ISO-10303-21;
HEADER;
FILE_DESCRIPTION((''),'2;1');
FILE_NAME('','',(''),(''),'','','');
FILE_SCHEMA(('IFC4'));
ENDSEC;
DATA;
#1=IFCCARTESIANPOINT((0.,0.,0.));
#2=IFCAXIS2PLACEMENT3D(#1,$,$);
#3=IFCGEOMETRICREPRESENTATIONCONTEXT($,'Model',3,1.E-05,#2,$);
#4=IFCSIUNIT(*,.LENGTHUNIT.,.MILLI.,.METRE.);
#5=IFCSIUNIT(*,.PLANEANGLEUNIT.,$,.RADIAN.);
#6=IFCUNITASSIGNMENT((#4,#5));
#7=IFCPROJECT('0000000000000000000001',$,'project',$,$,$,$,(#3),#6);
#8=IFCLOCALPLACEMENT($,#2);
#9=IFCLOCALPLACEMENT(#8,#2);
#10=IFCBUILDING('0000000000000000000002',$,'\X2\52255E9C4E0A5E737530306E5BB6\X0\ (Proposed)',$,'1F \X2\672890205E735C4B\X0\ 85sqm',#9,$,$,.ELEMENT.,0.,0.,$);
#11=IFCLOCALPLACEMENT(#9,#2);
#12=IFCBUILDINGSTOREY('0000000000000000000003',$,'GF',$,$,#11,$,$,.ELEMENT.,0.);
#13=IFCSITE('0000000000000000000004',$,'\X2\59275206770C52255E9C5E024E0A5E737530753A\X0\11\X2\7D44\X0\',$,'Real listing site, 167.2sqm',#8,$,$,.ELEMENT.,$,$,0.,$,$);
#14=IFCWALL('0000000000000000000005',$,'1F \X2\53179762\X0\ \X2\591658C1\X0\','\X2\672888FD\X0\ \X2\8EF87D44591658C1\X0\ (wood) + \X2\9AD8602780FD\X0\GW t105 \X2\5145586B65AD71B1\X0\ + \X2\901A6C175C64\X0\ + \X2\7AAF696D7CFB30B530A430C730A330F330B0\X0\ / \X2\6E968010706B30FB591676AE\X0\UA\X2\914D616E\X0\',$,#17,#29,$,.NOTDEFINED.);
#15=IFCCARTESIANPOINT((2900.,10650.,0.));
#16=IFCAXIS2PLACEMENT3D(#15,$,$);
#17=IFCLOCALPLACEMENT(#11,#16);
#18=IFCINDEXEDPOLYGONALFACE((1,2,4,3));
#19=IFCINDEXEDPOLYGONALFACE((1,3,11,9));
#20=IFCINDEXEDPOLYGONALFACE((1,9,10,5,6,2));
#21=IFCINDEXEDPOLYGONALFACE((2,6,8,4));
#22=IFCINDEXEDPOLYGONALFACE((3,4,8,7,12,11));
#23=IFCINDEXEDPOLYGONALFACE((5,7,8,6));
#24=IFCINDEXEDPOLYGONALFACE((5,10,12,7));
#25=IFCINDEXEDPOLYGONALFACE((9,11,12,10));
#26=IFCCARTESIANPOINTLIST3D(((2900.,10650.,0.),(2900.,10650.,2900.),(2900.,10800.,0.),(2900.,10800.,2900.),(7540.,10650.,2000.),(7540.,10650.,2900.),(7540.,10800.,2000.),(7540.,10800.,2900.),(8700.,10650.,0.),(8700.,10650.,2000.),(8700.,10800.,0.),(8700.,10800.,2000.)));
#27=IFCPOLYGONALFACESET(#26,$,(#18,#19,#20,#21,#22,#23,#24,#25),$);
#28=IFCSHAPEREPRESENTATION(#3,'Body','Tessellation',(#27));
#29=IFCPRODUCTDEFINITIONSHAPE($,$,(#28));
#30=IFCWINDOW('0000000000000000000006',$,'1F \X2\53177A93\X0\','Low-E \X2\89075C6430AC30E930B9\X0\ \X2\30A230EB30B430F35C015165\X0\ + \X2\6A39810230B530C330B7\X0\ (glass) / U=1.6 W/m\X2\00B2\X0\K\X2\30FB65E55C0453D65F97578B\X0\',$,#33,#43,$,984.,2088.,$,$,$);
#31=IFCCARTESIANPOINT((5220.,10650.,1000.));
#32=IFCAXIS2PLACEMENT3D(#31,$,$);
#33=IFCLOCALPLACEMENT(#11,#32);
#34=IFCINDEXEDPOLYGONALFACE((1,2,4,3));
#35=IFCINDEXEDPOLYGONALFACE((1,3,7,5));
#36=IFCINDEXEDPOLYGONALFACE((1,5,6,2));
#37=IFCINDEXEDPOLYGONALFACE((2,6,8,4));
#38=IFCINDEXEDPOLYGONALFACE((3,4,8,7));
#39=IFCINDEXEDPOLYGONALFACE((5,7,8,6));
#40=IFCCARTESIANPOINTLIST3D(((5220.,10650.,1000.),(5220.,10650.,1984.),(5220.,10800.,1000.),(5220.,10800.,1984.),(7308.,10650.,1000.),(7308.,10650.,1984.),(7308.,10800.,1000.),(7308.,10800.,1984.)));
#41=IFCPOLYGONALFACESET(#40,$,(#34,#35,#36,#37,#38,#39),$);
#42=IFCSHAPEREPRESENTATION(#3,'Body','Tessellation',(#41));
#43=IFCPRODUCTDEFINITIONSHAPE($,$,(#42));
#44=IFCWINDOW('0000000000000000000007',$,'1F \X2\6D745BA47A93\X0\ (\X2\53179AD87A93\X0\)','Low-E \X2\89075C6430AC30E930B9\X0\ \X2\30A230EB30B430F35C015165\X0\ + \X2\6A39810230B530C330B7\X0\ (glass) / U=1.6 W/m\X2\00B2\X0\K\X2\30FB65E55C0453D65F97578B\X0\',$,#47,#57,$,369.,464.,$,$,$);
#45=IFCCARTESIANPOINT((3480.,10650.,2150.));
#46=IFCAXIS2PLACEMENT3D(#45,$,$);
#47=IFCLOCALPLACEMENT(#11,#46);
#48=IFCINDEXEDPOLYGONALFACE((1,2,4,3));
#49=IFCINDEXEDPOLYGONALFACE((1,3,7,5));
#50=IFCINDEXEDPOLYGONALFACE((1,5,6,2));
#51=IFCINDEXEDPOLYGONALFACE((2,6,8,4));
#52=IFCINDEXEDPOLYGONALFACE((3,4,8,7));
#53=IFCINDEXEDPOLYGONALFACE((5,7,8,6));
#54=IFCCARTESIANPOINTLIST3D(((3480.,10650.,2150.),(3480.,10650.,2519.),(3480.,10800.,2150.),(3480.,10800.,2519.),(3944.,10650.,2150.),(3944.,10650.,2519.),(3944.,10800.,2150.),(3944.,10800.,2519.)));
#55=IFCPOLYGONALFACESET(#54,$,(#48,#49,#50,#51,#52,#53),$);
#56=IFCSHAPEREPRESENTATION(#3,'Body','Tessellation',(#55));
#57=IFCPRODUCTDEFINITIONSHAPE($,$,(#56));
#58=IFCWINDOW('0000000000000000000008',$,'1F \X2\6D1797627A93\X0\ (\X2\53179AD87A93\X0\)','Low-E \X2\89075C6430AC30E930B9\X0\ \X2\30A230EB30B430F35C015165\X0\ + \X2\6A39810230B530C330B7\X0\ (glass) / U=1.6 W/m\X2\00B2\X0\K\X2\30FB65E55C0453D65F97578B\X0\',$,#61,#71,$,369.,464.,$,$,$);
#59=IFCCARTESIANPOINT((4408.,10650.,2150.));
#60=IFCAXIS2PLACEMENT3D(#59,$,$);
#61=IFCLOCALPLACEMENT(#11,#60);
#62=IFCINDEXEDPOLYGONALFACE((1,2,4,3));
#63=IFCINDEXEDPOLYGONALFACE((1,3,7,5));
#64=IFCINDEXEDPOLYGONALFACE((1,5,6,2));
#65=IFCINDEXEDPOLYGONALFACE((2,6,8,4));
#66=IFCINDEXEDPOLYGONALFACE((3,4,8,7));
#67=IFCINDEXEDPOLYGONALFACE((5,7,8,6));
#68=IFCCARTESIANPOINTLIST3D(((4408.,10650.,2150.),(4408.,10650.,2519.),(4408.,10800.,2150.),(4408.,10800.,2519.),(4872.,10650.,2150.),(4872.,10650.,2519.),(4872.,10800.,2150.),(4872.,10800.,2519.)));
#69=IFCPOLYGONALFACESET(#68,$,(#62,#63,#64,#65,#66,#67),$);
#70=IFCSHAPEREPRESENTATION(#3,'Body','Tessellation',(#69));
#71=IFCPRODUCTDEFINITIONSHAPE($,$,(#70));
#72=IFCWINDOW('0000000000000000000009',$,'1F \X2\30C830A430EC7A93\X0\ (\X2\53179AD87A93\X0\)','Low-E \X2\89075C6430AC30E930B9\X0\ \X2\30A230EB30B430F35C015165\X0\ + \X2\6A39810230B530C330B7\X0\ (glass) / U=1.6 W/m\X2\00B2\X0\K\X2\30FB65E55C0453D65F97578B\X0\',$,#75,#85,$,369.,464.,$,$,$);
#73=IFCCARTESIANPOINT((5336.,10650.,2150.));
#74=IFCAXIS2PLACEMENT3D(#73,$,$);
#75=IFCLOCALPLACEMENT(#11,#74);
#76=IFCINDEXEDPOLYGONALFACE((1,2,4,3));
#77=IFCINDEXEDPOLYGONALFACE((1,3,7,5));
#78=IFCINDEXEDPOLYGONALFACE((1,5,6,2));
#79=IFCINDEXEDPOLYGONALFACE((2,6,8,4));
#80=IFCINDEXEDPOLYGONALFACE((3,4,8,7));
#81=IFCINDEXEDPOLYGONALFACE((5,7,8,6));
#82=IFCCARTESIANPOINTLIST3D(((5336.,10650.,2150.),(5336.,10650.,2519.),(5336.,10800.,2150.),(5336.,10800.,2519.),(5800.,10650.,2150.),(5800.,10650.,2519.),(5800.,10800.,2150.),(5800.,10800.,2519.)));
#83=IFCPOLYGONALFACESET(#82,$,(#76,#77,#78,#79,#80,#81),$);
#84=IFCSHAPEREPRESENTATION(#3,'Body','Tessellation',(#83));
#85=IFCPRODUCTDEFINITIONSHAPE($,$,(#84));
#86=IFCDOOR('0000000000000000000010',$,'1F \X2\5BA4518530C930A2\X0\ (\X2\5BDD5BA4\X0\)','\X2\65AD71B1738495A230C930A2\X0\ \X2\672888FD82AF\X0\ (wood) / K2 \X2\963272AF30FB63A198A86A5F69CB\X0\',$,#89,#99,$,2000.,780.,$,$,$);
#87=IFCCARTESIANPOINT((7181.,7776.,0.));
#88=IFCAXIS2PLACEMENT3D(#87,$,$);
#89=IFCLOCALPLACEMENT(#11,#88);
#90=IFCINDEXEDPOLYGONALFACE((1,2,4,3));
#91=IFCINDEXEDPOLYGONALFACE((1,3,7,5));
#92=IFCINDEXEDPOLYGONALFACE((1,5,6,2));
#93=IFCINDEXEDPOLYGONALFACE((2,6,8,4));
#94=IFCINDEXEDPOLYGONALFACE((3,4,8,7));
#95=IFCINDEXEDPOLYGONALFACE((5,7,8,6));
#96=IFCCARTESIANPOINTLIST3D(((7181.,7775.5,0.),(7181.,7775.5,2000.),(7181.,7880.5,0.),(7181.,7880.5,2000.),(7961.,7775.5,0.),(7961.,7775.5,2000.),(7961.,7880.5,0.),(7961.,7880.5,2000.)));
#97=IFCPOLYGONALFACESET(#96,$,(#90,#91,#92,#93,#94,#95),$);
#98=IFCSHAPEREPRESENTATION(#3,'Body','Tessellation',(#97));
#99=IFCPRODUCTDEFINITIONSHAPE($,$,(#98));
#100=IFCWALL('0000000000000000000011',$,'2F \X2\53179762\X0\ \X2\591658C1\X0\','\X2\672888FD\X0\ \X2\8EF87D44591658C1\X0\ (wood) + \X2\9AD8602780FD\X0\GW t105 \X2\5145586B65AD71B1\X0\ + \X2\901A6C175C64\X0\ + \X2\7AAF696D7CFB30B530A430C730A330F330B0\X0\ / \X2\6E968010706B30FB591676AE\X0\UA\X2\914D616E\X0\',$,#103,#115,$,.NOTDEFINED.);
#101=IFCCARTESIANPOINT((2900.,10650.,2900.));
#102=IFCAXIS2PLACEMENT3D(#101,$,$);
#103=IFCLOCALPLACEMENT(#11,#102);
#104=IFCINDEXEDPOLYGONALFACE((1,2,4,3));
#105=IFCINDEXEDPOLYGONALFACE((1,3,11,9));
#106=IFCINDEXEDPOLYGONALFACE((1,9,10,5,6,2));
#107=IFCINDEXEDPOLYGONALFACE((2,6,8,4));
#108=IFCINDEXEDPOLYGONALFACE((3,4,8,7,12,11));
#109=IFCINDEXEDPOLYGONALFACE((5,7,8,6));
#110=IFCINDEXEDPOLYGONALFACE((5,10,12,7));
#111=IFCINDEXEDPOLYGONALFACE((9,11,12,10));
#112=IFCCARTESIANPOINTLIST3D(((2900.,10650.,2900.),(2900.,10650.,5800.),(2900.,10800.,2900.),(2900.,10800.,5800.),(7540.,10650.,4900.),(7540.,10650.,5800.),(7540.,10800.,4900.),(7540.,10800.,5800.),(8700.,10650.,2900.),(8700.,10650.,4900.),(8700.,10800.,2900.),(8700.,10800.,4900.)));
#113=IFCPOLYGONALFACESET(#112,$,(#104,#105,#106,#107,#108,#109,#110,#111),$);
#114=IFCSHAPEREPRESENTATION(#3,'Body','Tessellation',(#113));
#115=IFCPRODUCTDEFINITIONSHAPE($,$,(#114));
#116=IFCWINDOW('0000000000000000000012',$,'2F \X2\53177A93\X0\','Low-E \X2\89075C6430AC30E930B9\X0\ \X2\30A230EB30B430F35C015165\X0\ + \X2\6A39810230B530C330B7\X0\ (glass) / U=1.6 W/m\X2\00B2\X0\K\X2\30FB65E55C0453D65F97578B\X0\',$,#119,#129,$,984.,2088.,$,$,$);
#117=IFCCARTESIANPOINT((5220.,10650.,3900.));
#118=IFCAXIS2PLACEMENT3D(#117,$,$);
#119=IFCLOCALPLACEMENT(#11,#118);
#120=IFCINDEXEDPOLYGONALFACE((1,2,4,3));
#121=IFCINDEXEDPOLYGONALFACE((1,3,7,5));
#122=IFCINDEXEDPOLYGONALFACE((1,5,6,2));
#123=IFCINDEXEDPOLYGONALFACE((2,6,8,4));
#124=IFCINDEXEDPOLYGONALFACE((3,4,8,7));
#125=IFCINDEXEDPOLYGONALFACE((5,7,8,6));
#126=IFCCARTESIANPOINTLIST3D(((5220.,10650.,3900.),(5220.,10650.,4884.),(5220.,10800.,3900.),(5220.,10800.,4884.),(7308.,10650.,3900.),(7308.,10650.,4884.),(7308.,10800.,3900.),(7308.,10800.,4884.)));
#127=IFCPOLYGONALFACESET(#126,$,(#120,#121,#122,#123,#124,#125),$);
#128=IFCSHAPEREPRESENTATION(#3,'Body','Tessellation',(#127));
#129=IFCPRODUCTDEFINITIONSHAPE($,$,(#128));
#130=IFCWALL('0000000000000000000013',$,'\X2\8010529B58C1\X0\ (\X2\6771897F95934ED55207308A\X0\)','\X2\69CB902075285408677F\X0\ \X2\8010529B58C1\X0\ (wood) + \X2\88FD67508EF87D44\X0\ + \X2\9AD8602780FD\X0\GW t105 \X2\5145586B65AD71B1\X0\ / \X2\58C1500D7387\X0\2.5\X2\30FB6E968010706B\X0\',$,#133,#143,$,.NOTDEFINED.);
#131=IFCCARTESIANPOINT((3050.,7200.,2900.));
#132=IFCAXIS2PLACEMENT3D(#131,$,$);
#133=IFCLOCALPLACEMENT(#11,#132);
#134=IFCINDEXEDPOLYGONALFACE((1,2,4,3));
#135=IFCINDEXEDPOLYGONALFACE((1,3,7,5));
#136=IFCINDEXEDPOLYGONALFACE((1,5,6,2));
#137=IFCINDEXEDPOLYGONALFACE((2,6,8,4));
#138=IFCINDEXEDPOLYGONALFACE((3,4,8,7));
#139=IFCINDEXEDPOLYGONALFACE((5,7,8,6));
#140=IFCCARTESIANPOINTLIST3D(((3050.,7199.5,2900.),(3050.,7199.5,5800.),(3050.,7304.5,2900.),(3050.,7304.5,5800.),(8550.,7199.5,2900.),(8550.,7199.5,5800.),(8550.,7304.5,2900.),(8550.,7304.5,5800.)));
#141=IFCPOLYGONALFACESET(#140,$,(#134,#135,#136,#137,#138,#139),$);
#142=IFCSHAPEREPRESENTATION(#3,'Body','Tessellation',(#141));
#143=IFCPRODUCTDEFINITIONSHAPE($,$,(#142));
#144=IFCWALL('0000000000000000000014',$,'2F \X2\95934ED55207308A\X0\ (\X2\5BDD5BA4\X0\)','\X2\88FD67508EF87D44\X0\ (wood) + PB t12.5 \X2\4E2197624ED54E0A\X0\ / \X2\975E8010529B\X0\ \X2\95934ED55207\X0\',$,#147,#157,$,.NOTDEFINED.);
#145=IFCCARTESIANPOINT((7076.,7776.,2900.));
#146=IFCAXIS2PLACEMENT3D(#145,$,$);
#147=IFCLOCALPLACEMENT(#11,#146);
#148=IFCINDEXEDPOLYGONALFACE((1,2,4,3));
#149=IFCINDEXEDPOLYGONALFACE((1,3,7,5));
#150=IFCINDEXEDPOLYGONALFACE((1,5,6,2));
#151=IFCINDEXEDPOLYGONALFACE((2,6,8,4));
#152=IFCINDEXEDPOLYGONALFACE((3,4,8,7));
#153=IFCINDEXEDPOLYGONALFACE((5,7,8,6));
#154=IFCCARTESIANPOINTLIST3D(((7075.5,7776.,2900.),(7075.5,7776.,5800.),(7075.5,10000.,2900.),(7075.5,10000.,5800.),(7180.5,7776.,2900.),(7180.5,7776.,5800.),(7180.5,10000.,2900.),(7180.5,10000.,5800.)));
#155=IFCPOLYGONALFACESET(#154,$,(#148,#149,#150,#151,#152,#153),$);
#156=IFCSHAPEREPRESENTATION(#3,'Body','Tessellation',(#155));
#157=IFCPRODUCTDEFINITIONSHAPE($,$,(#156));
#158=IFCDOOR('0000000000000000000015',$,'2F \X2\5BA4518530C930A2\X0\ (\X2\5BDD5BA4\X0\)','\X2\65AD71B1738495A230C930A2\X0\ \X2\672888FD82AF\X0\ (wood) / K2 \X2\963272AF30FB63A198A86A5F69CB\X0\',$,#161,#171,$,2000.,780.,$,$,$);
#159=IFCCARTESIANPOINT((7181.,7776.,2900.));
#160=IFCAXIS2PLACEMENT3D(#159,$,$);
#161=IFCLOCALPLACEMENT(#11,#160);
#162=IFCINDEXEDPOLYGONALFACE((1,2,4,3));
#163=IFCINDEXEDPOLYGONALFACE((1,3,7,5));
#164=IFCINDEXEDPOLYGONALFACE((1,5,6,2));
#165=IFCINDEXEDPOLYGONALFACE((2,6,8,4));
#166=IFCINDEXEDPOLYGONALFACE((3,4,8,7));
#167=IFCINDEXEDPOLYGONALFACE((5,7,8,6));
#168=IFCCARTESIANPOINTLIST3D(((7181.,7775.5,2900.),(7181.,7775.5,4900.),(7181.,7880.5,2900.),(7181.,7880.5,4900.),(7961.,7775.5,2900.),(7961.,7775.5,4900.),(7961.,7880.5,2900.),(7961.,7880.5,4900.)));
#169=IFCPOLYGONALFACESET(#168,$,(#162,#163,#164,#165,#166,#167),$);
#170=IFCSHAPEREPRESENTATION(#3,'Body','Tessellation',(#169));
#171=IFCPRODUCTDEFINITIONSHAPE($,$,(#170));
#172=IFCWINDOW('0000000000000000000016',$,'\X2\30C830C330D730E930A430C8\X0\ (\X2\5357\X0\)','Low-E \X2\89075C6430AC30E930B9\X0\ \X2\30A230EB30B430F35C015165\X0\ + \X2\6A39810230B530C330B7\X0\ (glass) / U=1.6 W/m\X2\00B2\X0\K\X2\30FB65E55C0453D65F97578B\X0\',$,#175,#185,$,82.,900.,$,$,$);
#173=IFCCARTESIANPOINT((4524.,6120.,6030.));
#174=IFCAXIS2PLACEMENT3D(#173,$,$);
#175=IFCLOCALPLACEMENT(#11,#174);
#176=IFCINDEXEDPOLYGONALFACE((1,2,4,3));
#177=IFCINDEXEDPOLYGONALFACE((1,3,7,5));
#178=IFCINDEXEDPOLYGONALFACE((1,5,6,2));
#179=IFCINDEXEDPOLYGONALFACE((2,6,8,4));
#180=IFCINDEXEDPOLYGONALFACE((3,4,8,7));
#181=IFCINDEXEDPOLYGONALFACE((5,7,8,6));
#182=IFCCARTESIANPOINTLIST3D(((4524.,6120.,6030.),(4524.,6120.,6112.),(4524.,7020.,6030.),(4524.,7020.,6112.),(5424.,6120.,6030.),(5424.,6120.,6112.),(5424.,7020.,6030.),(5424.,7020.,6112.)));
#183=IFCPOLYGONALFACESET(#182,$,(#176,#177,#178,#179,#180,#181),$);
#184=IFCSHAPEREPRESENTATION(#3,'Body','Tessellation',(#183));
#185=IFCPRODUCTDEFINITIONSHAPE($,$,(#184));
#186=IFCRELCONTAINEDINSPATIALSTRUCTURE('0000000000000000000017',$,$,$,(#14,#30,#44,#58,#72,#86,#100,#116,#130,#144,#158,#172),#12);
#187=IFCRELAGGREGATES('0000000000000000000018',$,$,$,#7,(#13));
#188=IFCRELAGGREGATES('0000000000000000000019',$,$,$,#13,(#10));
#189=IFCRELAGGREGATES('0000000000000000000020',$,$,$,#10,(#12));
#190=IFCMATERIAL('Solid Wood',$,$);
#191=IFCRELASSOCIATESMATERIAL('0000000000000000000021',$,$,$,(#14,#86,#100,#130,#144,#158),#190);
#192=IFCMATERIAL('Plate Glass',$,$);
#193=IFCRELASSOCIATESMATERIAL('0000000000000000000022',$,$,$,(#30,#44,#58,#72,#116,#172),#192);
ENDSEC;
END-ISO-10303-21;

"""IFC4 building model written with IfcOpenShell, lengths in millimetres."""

from ifc_helpers import new_model, si_unit, frame, frame_2d, origin, place, context, project, spatial, rectangle, extrude, material, element, fill, save


model = new_model("IFC4")

# Units and contexts
model_context = context("Model", 3, precision=1e-05, world=origin())
ifc_project = project(units=[si_unit("LENGTHUNIT", "METRE", prefix="MILLI"), si_unit("PLANEANGLEUNIT", "RADIAN")], contexts=[model_context])

# Site, building, storey
site_placement = place(None, origin())
site = spatial("IfcSite", under=ifc_project, at=site_placement, Name="大分県別府市上平田町11組", ObjectType="Real listing site, 167.2sqm", CompositionType="ELEMENT", RefElevation=0.0)
building_placement = place(site_placement, origin())
building = spatial("IfcBuilding", under=site, at=building_placement, Name="別府上平田の家 (Proposed)", ObjectType="1F 木造平屋 85sqm", CompositionType="ELEMENT", ElevationOfRefHeight=0.0, ElevationOfTerrain=0.0)
storey_placement = place(building_placement, origin())
storey = spatial("IfcBuildingStorey", under=building, at=storey_placement, Name="GF", CompositionType="ELEMENT", Elevation=0.0)

# Wall, openings, windows
ifc_material_1 = material(Name="Solid Wood")
wall_1_placement = place(storey_placement, frame((2900.0, 10650.0, 0.0)))
wall_1 = element("IfcWall", 1, at=wall_1_placement, inside=storey, material=ifc_material_1, Name="1F 北面 外壁", Description="木製 軸組外壁 (wood) + 高性能GW t105 充填断熱 + 通気層 + 窯業系サイディング / 準耐火・外皮UA配慮", PredefinedType="NOTDEFINED", context=model_context, shape_type="SweptSolid", body=[
    extrude(rectangle(XDim=5800.0, YDim=150.0, at=frame_2d((2900.0, 75.0))), frame((2900.0, 10650.0, 0.0)), (0.0, 0.0, 1.0), 2900.0),
])
opening_1_placement = place(storey_placement, frame((5220.0, 10650.0, 1000.0)))
opening_1 = element("IfcOpeningElement", 2, at=opening_1_placement, cuts=wall_1, PredefinedType="NOTDEFINED", context=model_context, shape_type="SweptSolid", body=[
    extrude(rectangle(XDim=2088.0, YDim=150.0, at=frame_2d((1044.0, 75.0))), frame((5220.0, 10650.0, 1000.0)), (0.0, 0.0, 1.0), 984.0),
])
opening_2_placement = place(storey_placement, frame((3480.0, 10650.0, 2150.0)))
opening_2 = element("IfcOpeningElement", 3, at=opening_2_placement, cuts=wall_1, PredefinedType="NOTDEFINED", context=model_context, shape_type="SweptSolid", body=[
    extrude(rectangle(XDim=464.0, YDim=150.0, at=frame_2d((232.0, 75.0))), frame((3480.0, 10650.0, 2150.0)), (0.0, 0.0, 1.0), 369.0),
])
opening_3_placement = place(storey_placement, frame((4408.0, 10650.0, 2150.0)))
opening_3 = element("IfcOpeningElement", 4, at=opening_3_placement, cuts=wall_1, PredefinedType="NOTDEFINED", context=model_context, shape_type="SweptSolid", body=[
    extrude(rectangle(XDim=464.0, YDim=150.0, at=frame_2d((232.0, 75.0))), frame((4408.0, 10650.0, 2150.0)), (0.0, 0.0, 1.0), 369.0),
])
opening_4_placement = place(storey_placement, frame((5336.0, 10650.0, 2150.0)))
opening_4 = element("IfcOpeningElement", 5, at=opening_4_placement, cuts=wall_1, PredefinedType="NOTDEFINED", context=model_context, shape_type="SweptSolid", body=[
    extrude(rectangle(XDim=464.0, YDim=150.0, at=frame_2d((232.0, 75.0))), frame((5336.0, 10650.0, 2150.0)), (0.0, 0.0, 1.0), 369.0),
])
ifc_material_2 = material(Name="Plate Glass")
window_1_placement = place(storey_placement, frame((5220.0, 10650.0, 1000.0)))
window_1 = element("IfcWindow", 6, at=window_1_placement, inside=storey, material=ifc_material_2, Name="1F 北窓", Description="Low-E 複層ガラス アルゴン封入 + 樹脂サッシ (glass) / U=1.6 W/m²K・日射取得型", OverallHeight=984.0, OverallWidth=2088.0, context=model_context, shape_type="SweptSolid", body=[
    extrude(rectangle(XDim=2088.0, YDim=150.0, at=frame_2d((1044.0, 75.0))), frame((5220.0, 10650.0, 1000.0)), (0.0, 0.0, 1.0), 984.0),
])
fill(opening_1, window_1)
window_2_placement = place(storey_placement, frame((3480.0, 10650.0, 2150.0)))
window_2 = element("IfcWindow", 7, at=window_2_placement, inside=storey, material=ifc_material_2, Name="1F 浴室窓 (北高窓)", Description="Low-E 複層ガラス アルゴン封入 + 樹脂サッシ (glass) / U=1.6 W/m²K・日射取得型", OverallHeight=369.0, OverallWidth=464.0, context=model_context, shape_type="SweptSolid", body=[
    extrude(rectangle(XDim=464.0, YDim=150.0, at=frame_2d((232.0, 75.0))), frame((3480.0, 10650.0, 2150.0)), (0.0, 0.0, 1.0), 369.0),
])
fill(opening_2, window_2)
window_3_placement = place(storey_placement, frame((4408.0, 10650.0, 2150.0)))
window_3 = element("IfcWindow", 8, at=window_3_placement, inside=storey, material=ifc_material_2, Name="1F 洗面窓 (北高窓)", Description="Low-E 複層ガラス アルゴン封入 + 樹脂サッシ (glass) / U=1.6 W/m²K・日射取得型", OverallHeight=369.0, OverallWidth=464.0, context=model_context, shape_type="SweptSolid", body=[
    extrude(rectangle(XDim=464.0, YDim=150.0, at=frame_2d((232.0, 75.0))), frame((4408.0, 10650.0, 2150.0)), (0.0, 0.0, 1.0), 369.0),
])
fill(opening_3, window_3)
window_4_placement = place(storey_placement, frame((5336.0, 10650.0, 2150.0)))
window_4 = element("IfcWindow", 9, at=window_4_placement, inside=storey, material=ifc_material_2, Name="1F トイレ窓 (北高窓)", Description="Low-E 複層ガラス アルゴン封入 + 樹脂サッシ (glass) / U=1.6 W/m²K・日射取得型", OverallHeight=369.0, OverallWidth=464.0, context=model_context, shape_type="SweptSolid", body=[
    extrude(rectangle(XDim=464.0, YDim=150.0, at=frame_2d((232.0, 75.0))), frame((5336.0, 10650.0, 2150.0)), (0.0, 0.0, 1.0), 369.0),
])
fill(opening_4, window_4)

# Door
door_1_placement = place(storey_placement, frame((7181.0, 7776.0, 0.0)))
element("IfcDoor", 10, at=door_1_placement, inside=storey, material=ifc_material_1, Name="1F 室内ドア (寝室)", Description="断熱玄関ドア 木製芯 (wood) / K2 防犯・採風機構", OverallHeight=2000.0, OverallWidth=780.0, context=model_context, shape_type="SweptSolid", body=[
    extrude(rectangle(XDim=780.0, YDim=105.0, at=frame_2d((390.0, 52.0))), frame((7181.0, 7776.0, 0.0)), (0.0, 0.0, 1.0), 2000.0),
])

# Wall, opening, window
wall_2_placement = place(storey_placement, frame((2900.0, 10650.0, 2900.0)))
wall_2 = element("IfcWall", 11, at=wall_2_placement, inside=storey, material=ifc_material_1, Name="2F 北面 外壁", Description="木製 軸組外壁 (wood) + 高性能GW t105 充填断熱 + 通気層 + 窯業系サイディング / 準耐火・外皮UA配慮", PredefinedType="NOTDEFINED", context=model_context, shape_type="SweptSolid", body=[
    extrude(rectangle(XDim=5800.0, YDim=150.0, at=frame_2d((2900.0, 75.0))), frame((2900.0, 10650.0, 2900.0)), (0.0, 0.0, 1.0), 2900.0),
])
opening_5_placement = place(storey_placement, frame((5220.0, 10650.0, 3900.0)))
opening_5 = element("IfcOpeningElement", 12, at=opening_5_placement, cuts=wall_2, PredefinedType="NOTDEFINED", context=model_context, shape_type="SweptSolid", body=[
    extrude(rectangle(XDim=2088.0, YDim=150.0, at=frame_2d((1044.0, 75.0))), frame((5220.0, 10650.0, 3900.0)), (0.0, 0.0, 1.0), 984.0),
])
window_5_placement = place(storey_placement, frame((5220.0, 10650.0, 3900.0)))
window_5 = element("IfcWindow", 13, at=window_5_placement, inside=storey, material=ifc_material_2, Name="2F 北窓", Description="Low-E 複層ガラス アルゴン封入 + 樹脂サッシ (glass) / U=1.6 W/m²K・日射取得型", OverallHeight=984.0, OverallWidth=2088.0, context=model_context, shape_type="SweptSolid", body=[
    extrude(rectangle(XDim=2088.0, YDim=150.0, at=frame_2d((1044.0, 75.0))), frame((5220.0, 10650.0, 3900.0)), (0.0, 0.0, 1.0), 984.0),
])
fill(opening_5, window_5)

# Walls
wall_3_placement = place(storey_placement, frame((3050.0, 7200.0, 2900.0)))
element("IfcWall", 14, at=wall_3_placement, inside=storey, material=ifc_material_1, Name="耐力壁 (東西間仕切り)", Description="構造用合板 耐力壁 (wood) + 製材軸組 + 高性能GW t105 充填断熱 / 壁倍率2.5・準耐火", PredefinedType="NOTDEFINED", context=model_context, shape_type="SweptSolid", body=[
    extrude(rectangle(XDim=5500.0, YDim=105.0, at=frame_2d((2750.0, 52.0))), frame((3050.0, 7200.0, 2900.0)), (0.0, 0.0, 1.0), 2900.0),
])
wall_4_placement = place(storey_placement, frame((7076.0, 7776.0, 2900.0)))
element("IfcWall", 15, at=wall_4_placement, inside=storey, material=ifc_material_1, Name="2F 間仕切り (寝室)", Description="製材軸組 (wood) + PB t12.5 両面仕上 / 非耐力 間仕切", PredefinedType="NOTDEFINED", context=model_context, shape_type="SweptSolid", body=[
    extrude(rectangle(XDim=105.0, YDim=2224.0, at=frame_2d((52.0, 1112.0))), frame((7076.0, 7776.0, 2900.0)), (0.0, 0.0, 1.0), 2900.0),
])

# Door
door_2_placement = place(storey_placement, frame((7181.0, 7776.0, 2900.0)))
element("IfcDoor", 16, at=door_2_placement, inside=storey, material=ifc_material_1, Name="2F 室内ドア (寝室)", Description="断熱玄関ドア 木製芯 (wood) / K2 防犯・採風機構", OverallHeight=2000.0, OverallWidth=780.0, context=model_context, shape_type="SweptSolid", body=[
    extrude(rectangle(XDim=780.0, YDim=105.0, at=frame_2d((390.0, 52.0))), frame((7181.0, 7776.0, 2900.0)), (0.0, 0.0, 1.0), 2000.0),
])

# Window
window_6_placement = place(storey_placement, frame((4524.0, 6120.0, 6030.0)))
element("IfcWindow", 17, at=window_6_placement, inside=storey, material=ifc_material_2, Name="トップライト (南)", Description="Low-E 複層ガラス アルゴン封入 + 樹脂サッシ (glass) / U=1.6 W/m²K・日射取得型", OverallHeight=82.0, OverallWidth=900.0, context=model_context, shape_type="SweptSolid", body=[
    extrude(rectangle(XDim=900.0, YDim=900.0, at=frame_2d((450.0, 450.0))), frame((4524.0, 6120.0, 6030.0)), (0.0, 0.0, 1.0), 82.0),
])

save(model, "model.ifc")
